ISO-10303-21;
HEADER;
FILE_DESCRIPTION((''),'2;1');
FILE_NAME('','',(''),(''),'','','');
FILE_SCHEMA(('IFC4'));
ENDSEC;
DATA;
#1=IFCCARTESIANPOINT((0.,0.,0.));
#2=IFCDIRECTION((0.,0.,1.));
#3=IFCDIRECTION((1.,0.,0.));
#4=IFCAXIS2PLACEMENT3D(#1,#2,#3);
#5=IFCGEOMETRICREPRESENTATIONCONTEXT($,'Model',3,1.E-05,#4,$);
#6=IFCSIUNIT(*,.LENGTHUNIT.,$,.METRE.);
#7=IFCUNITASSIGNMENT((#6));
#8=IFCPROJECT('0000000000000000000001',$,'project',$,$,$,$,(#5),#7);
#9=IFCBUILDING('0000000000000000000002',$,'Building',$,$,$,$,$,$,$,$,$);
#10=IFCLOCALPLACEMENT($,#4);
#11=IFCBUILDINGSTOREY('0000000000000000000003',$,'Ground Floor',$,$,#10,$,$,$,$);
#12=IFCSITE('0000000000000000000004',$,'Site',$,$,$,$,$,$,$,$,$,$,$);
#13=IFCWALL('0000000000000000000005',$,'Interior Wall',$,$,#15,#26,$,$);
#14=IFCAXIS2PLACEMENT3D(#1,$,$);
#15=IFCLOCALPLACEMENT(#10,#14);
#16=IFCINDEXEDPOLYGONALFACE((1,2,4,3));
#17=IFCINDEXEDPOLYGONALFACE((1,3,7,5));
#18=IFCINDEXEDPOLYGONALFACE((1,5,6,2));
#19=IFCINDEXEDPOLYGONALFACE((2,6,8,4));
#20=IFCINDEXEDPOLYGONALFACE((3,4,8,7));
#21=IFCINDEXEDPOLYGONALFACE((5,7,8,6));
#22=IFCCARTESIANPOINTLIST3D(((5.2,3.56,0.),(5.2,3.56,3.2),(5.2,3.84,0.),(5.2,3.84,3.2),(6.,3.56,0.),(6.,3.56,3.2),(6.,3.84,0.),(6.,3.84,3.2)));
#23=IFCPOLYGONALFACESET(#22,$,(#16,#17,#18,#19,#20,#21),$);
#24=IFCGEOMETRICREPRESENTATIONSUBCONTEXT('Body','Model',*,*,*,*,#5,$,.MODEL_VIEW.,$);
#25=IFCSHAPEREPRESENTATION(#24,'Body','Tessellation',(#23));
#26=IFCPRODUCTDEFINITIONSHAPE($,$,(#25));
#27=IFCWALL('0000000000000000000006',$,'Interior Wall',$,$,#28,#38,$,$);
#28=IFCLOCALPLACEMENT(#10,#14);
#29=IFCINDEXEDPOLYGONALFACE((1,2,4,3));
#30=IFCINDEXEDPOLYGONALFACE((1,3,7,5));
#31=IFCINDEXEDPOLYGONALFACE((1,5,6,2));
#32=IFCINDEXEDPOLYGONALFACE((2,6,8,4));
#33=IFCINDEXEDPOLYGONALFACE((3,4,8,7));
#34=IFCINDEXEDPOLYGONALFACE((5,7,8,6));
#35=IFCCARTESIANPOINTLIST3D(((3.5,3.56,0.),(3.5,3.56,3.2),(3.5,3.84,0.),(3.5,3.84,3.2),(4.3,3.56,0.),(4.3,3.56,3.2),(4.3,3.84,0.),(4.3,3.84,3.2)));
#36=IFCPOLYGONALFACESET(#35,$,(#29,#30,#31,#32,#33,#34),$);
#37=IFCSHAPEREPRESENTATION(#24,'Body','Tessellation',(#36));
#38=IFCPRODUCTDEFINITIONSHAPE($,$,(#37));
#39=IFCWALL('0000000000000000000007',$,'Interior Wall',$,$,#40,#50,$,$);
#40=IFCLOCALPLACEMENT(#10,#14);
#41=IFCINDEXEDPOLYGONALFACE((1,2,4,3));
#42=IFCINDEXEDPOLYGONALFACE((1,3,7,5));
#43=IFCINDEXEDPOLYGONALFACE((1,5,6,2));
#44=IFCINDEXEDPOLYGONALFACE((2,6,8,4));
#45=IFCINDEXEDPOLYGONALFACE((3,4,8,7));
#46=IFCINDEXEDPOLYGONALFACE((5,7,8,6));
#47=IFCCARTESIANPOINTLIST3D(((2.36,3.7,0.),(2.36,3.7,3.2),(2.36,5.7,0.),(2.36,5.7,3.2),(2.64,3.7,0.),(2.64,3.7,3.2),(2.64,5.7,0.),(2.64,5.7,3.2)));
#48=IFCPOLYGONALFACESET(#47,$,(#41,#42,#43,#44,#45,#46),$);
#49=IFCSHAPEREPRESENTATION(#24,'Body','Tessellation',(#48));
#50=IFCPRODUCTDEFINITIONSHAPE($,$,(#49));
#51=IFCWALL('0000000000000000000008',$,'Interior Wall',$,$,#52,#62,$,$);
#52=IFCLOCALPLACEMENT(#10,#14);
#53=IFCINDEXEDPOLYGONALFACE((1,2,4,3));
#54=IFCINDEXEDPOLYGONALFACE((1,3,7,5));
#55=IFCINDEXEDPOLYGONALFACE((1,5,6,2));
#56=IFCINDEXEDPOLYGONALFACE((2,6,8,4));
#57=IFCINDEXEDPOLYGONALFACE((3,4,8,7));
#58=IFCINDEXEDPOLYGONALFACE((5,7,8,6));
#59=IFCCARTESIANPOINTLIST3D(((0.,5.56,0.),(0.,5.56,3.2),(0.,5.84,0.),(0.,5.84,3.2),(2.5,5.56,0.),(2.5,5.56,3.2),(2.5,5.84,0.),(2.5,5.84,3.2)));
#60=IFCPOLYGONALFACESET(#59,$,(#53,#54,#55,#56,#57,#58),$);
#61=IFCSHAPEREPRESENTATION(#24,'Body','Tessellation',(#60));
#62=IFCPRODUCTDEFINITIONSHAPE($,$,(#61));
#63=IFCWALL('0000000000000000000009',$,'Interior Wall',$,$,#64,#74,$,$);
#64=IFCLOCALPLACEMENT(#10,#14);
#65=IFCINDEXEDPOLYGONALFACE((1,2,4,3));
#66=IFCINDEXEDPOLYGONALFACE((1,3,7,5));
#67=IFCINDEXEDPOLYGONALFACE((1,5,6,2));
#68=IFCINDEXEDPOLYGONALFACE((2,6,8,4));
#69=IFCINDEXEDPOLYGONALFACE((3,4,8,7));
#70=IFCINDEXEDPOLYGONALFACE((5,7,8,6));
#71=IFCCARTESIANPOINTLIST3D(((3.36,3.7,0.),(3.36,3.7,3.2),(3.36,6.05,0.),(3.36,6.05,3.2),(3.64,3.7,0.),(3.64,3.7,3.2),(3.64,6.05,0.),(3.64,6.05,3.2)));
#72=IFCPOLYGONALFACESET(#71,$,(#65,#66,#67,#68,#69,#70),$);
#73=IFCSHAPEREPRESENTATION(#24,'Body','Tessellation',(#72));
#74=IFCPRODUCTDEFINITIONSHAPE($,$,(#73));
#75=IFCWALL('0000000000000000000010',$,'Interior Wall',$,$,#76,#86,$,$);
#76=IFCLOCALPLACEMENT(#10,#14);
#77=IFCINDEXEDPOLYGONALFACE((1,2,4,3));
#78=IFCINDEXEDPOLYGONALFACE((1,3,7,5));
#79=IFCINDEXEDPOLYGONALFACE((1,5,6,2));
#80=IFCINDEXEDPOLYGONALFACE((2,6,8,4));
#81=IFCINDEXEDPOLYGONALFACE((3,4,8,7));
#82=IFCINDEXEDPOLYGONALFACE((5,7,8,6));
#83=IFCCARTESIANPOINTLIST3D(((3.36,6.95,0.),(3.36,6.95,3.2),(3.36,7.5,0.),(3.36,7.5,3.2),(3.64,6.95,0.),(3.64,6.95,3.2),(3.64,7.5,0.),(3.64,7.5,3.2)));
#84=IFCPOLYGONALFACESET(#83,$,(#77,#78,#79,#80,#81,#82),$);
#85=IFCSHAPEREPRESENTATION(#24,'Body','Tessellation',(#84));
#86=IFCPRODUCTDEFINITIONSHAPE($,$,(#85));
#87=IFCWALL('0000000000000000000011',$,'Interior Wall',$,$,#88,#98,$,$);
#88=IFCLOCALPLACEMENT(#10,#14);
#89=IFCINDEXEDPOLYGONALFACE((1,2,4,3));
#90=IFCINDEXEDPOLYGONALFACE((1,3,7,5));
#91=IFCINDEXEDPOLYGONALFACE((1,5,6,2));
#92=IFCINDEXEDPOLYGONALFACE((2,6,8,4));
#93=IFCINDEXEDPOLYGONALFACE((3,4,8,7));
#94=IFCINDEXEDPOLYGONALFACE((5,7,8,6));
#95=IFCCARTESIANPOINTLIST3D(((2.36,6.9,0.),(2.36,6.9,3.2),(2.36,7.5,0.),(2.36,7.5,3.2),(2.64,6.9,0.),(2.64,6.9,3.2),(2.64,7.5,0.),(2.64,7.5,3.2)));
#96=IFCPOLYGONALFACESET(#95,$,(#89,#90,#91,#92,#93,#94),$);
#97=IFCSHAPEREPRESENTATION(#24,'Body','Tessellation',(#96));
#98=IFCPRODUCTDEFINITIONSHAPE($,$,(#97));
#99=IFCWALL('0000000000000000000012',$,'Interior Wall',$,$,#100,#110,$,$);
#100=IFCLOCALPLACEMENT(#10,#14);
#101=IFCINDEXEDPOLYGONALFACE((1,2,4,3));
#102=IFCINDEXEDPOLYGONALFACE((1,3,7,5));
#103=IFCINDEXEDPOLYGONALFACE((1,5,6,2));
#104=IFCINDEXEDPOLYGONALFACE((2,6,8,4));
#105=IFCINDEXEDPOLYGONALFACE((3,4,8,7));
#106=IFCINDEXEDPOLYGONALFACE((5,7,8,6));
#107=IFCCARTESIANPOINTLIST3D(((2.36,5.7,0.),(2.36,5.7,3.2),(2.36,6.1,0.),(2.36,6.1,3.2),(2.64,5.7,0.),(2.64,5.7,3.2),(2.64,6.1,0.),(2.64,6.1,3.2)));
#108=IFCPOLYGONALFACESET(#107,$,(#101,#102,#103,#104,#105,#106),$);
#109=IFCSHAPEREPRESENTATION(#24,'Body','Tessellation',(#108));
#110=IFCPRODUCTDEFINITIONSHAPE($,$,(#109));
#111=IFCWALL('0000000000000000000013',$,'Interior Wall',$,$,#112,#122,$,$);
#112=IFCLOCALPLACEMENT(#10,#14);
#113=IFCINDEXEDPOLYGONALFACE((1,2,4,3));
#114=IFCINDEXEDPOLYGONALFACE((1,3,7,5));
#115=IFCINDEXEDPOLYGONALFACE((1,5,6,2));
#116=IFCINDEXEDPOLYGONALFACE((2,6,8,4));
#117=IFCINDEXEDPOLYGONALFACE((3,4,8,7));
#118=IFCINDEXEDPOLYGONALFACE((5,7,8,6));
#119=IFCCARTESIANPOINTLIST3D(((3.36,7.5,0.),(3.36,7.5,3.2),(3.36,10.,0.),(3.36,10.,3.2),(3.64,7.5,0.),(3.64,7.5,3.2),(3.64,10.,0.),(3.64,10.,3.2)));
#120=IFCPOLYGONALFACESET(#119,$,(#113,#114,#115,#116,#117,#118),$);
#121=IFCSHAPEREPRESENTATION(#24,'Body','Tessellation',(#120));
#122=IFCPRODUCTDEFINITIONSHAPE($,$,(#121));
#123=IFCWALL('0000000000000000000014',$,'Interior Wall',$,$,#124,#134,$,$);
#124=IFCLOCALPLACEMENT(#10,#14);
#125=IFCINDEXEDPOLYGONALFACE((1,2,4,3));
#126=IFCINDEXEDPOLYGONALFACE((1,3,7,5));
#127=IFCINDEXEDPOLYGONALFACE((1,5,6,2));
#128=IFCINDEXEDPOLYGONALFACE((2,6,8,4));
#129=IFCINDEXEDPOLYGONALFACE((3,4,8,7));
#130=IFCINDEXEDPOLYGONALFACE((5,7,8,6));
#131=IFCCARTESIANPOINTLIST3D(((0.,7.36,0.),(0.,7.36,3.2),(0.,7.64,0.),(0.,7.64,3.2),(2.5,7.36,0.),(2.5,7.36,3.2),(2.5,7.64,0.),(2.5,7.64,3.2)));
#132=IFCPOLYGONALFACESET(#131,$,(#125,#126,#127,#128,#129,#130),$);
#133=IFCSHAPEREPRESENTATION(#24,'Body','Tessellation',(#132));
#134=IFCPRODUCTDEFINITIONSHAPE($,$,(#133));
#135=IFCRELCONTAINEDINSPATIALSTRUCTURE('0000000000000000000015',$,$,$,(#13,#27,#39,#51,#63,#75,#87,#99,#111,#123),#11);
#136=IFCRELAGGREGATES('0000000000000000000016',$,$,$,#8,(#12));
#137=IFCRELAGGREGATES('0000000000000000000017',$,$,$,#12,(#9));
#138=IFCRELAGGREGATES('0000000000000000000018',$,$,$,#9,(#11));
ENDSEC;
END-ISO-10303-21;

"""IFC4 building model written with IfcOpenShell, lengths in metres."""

from ifc_helpers import new_model, si_unit, frame, origin_with_axes, place, context, subcontext, project, spatial, indexed_curve, outline, extrude, element, save


model = new_model("IFC4")

# Units and contexts
model_context = context("Model", 3, precision=1e-05, world=origin_with_axes())
body_context = subcontext(model_context, "Body", "Model", "MODEL_VIEW")
ifc_project = project(units=[si_unit("LENGTHUNIT", "METRE")], contexts=[model_context])

# Site, building, storey
site = spatial("IfcSite", under=ifc_project, Name="Site")
building = spatial("IfcBuilding", under=site, Name="Building")
storey_placement = place(None, origin_with_axes())
storey = spatial("IfcBuildingStorey", under=building, at=storey_placement, Name="Ground Floor")

# Walls
for number, where, z_axis, x_axis, name in (
    (1, (6.0, 3.7, 0.0), (0.0, 0.0, 1.0), (-1.0, 0.0, 0.0), "Interior Wall"),
    (2, (4.3, 3.7, 0.0), (0.0, 0.0, 1.0), (-1.0, 0.0, 0.0), "Interior Wall"),
):
    element("IfcWall", number, at=place(storey_placement, frame(where, z_axis=z_axis, x_axis=x_axis)), inside=storey, Name=name, context=body_context, shape_type="SweptSolid", body=[
        extrude(outline(indexed_curve([(0.0, 0.0), (0.0, 0.28), (0.8, 0.28), (0.8, 0.0), (0.0, 0.0)], self_intersect=False)), frame((0.0, -0.14, 0.0), z_axis=(0.0, 0.0, 1.0), x_axis=(1.0, 0.0, 0.0)), (0.0, 0.0, 1.0), 3.2),
    ])
wall_1_placement = place(storey_placement, frame((2.5, 3.7, 0.0), z_axis=(0.0, 0.0, 1.0), x_axis=(0.0, 1.0, 0.0)))
element("IfcWall", 3, at=wall_1_placement, inside=storey, Name="Interior Wall", context=body_context, shape_type="SweptSolid", body=[
    extrude(outline(indexed_curve([(0.0, 0.0), (0.0, 0.28), (2.0, 0.28), (2.0, 0.0), (0.0, 0.0)], self_intersect=False)), frame((0.0, -0.14, 0.0), z_axis=(0.0, 0.0, 1.0), x_axis=(1.0, 0.0, 0.0)), (0.0, 0.0, 1.0), 3.2),
])
wall_2_placement = place(storey_placement, frame((2.5, 5.7, 0.0), z_axis=(0.0, 0.0, 1.0), x_axis=(-1.0, 0.0, 0.0)))
element("IfcWall", 4, at=wall_2_placement, inside=storey, Name="Interior Wall", context=body_context, shape_type="SweptSolid", body=[
    extrude(outline(indexed_curve([(0.0, 0.0), (0.0, 0.28), (2.5, 0.28), (2.5, 0.0), (0.0, 0.0)], self_intersect=False)), frame((0.0, -0.14, 0.0), z_axis=(0.0, 0.0, 1.0), x_axis=(1.0, 0.0, 0.0)), (0.0, 0.0, 1.0), 3.2),
])
wall_3_placement = place(storey_placement, frame((3.5, 3.7, 0.0), z_axis=(0.0, 0.0, 1.0), x_axis=(0.0, 1.0, 0.0)))
element("IfcWall", 5, at=wall_3_placement, inside=storey, Name="Interior Wall", context=body_context, shape_type="SweptSolid", body=[
    extrude(outline(indexed_curve([(0.0, 0.0), (0.0, 0.28), (2.35, 0.28), (2.35, 0.0), (0.0, 0.0)], self_intersect=False)), frame((0.0, -0.14, 0.0), z_axis=(0.0, 0.0, 1.0), x_axis=(1.0, 0.0, 0.0)), (0.0, 0.0, 1.0), 3.2),
])
wall_4_placement = place(storey_placement, frame((3.5, 6.95, 0.0), z_axis=(0.0, 0.0, 1.0), x_axis=(0.0, 1.0, 0.0)))
element("IfcWall", 6, at=wall_4_placement, inside=storey, Name="Interior Wall", context=body_context, shape_type="SweptSolid", body=[
    extrude(outline(indexed_curve([(0.0, 0.0), (0.0, 0.28), (0.55, 0.28), (0.55, 0.0), (0.0, 0.0)], self_intersect=False)), frame((0.0, -0.14, 0.0), z_axis=(0.0, 0.0, 1.0), x_axis=(1.0, 0.0, 0.0)), (0.0, 0.0, 1.0), 3.2),
])
wall_5_placement = place(storey_placement, frame((2.5, 7.5, 0.0), z_axis=(0.0, 0.0, 1.0), x_axis=(0.0, -1.0, 0.0)))
element("IfcWall", 7, at=wall_5_placement, inside=storey, Name="Interior Wall", context=body_context, shape_type="SweptSolid", body=[
    extrude(outline(indexed_curve([(0.0, 0.0), (0.0, 0.28), (0.6, 0.28), (0.6, 0.0), (0.0, 0.0)], self_intersect=False)), frame((0.0, -0.14, 0.0), z_axis=(0.0, 0.0, 1.0), x_axis=(1.0, 0.0, 0.0)), (0.0, 0.0, 1.0), 3.2),
])
wall_6_placement = place(storey_placement, frame((2.5, 6.1, 0.0), z_axis=(0.0, 0.0, 1.0), x_axis=(0.0, -1.0, 0.0)))
element("IfcWall", 8, at=wall_6_placement, inside=storey, Name="Interior Wall", context=body_context, shape_type="SweptSolid", body=[
    extrude(outline(indexed_curve([(0.0, 0.0), (0.0, 0.28), (0.4, 0.28), (0.4, 0.0), (0.0, 0.0)], self_intersect=False)), frame((0.0, -0.14, 0.0), z_axis=(0.0, 0.0, 1.0), x_axis=(1.0, 0.0, 0.0)), (0.0, 0.0, 1.0), 3.2),
])
for number, where, z_axis, x_axis, name in (
    (9, (3.5, 10.0, 0.0), (0.0, 0.0, 1.0), (0.0, -1.0, 0.0), "Interior Wall"),
    (10, (2.5, 7.5, 0.0), (0.0, 0.0, 1.0), (-1.0, 0.0, 0.0), "Interior Wall"),
):
    element("IfcWall", number, at=place(storey_placement, frame(where, z_axis=z_axis, x_axis=x_axis)), inside=storey, Name=name, context=body_context, shape_type="SweptSolid", body=[
        extrude(outline(indexed_curve([(0.0, 0.0), (0.0, 0.28), (2.5, 0.28), (2.5, 0.0), (0.0, 0.0)], self_intersect=False)), frame((0.0, -0.14, 0.0), z_axis=(0.0, 0.0, 1.0), x_axis=(1.0, 0.0, 0.0)), (0.0, 0.0, 1.0), 3.2),
    ])

save(model, "model.ifc")
